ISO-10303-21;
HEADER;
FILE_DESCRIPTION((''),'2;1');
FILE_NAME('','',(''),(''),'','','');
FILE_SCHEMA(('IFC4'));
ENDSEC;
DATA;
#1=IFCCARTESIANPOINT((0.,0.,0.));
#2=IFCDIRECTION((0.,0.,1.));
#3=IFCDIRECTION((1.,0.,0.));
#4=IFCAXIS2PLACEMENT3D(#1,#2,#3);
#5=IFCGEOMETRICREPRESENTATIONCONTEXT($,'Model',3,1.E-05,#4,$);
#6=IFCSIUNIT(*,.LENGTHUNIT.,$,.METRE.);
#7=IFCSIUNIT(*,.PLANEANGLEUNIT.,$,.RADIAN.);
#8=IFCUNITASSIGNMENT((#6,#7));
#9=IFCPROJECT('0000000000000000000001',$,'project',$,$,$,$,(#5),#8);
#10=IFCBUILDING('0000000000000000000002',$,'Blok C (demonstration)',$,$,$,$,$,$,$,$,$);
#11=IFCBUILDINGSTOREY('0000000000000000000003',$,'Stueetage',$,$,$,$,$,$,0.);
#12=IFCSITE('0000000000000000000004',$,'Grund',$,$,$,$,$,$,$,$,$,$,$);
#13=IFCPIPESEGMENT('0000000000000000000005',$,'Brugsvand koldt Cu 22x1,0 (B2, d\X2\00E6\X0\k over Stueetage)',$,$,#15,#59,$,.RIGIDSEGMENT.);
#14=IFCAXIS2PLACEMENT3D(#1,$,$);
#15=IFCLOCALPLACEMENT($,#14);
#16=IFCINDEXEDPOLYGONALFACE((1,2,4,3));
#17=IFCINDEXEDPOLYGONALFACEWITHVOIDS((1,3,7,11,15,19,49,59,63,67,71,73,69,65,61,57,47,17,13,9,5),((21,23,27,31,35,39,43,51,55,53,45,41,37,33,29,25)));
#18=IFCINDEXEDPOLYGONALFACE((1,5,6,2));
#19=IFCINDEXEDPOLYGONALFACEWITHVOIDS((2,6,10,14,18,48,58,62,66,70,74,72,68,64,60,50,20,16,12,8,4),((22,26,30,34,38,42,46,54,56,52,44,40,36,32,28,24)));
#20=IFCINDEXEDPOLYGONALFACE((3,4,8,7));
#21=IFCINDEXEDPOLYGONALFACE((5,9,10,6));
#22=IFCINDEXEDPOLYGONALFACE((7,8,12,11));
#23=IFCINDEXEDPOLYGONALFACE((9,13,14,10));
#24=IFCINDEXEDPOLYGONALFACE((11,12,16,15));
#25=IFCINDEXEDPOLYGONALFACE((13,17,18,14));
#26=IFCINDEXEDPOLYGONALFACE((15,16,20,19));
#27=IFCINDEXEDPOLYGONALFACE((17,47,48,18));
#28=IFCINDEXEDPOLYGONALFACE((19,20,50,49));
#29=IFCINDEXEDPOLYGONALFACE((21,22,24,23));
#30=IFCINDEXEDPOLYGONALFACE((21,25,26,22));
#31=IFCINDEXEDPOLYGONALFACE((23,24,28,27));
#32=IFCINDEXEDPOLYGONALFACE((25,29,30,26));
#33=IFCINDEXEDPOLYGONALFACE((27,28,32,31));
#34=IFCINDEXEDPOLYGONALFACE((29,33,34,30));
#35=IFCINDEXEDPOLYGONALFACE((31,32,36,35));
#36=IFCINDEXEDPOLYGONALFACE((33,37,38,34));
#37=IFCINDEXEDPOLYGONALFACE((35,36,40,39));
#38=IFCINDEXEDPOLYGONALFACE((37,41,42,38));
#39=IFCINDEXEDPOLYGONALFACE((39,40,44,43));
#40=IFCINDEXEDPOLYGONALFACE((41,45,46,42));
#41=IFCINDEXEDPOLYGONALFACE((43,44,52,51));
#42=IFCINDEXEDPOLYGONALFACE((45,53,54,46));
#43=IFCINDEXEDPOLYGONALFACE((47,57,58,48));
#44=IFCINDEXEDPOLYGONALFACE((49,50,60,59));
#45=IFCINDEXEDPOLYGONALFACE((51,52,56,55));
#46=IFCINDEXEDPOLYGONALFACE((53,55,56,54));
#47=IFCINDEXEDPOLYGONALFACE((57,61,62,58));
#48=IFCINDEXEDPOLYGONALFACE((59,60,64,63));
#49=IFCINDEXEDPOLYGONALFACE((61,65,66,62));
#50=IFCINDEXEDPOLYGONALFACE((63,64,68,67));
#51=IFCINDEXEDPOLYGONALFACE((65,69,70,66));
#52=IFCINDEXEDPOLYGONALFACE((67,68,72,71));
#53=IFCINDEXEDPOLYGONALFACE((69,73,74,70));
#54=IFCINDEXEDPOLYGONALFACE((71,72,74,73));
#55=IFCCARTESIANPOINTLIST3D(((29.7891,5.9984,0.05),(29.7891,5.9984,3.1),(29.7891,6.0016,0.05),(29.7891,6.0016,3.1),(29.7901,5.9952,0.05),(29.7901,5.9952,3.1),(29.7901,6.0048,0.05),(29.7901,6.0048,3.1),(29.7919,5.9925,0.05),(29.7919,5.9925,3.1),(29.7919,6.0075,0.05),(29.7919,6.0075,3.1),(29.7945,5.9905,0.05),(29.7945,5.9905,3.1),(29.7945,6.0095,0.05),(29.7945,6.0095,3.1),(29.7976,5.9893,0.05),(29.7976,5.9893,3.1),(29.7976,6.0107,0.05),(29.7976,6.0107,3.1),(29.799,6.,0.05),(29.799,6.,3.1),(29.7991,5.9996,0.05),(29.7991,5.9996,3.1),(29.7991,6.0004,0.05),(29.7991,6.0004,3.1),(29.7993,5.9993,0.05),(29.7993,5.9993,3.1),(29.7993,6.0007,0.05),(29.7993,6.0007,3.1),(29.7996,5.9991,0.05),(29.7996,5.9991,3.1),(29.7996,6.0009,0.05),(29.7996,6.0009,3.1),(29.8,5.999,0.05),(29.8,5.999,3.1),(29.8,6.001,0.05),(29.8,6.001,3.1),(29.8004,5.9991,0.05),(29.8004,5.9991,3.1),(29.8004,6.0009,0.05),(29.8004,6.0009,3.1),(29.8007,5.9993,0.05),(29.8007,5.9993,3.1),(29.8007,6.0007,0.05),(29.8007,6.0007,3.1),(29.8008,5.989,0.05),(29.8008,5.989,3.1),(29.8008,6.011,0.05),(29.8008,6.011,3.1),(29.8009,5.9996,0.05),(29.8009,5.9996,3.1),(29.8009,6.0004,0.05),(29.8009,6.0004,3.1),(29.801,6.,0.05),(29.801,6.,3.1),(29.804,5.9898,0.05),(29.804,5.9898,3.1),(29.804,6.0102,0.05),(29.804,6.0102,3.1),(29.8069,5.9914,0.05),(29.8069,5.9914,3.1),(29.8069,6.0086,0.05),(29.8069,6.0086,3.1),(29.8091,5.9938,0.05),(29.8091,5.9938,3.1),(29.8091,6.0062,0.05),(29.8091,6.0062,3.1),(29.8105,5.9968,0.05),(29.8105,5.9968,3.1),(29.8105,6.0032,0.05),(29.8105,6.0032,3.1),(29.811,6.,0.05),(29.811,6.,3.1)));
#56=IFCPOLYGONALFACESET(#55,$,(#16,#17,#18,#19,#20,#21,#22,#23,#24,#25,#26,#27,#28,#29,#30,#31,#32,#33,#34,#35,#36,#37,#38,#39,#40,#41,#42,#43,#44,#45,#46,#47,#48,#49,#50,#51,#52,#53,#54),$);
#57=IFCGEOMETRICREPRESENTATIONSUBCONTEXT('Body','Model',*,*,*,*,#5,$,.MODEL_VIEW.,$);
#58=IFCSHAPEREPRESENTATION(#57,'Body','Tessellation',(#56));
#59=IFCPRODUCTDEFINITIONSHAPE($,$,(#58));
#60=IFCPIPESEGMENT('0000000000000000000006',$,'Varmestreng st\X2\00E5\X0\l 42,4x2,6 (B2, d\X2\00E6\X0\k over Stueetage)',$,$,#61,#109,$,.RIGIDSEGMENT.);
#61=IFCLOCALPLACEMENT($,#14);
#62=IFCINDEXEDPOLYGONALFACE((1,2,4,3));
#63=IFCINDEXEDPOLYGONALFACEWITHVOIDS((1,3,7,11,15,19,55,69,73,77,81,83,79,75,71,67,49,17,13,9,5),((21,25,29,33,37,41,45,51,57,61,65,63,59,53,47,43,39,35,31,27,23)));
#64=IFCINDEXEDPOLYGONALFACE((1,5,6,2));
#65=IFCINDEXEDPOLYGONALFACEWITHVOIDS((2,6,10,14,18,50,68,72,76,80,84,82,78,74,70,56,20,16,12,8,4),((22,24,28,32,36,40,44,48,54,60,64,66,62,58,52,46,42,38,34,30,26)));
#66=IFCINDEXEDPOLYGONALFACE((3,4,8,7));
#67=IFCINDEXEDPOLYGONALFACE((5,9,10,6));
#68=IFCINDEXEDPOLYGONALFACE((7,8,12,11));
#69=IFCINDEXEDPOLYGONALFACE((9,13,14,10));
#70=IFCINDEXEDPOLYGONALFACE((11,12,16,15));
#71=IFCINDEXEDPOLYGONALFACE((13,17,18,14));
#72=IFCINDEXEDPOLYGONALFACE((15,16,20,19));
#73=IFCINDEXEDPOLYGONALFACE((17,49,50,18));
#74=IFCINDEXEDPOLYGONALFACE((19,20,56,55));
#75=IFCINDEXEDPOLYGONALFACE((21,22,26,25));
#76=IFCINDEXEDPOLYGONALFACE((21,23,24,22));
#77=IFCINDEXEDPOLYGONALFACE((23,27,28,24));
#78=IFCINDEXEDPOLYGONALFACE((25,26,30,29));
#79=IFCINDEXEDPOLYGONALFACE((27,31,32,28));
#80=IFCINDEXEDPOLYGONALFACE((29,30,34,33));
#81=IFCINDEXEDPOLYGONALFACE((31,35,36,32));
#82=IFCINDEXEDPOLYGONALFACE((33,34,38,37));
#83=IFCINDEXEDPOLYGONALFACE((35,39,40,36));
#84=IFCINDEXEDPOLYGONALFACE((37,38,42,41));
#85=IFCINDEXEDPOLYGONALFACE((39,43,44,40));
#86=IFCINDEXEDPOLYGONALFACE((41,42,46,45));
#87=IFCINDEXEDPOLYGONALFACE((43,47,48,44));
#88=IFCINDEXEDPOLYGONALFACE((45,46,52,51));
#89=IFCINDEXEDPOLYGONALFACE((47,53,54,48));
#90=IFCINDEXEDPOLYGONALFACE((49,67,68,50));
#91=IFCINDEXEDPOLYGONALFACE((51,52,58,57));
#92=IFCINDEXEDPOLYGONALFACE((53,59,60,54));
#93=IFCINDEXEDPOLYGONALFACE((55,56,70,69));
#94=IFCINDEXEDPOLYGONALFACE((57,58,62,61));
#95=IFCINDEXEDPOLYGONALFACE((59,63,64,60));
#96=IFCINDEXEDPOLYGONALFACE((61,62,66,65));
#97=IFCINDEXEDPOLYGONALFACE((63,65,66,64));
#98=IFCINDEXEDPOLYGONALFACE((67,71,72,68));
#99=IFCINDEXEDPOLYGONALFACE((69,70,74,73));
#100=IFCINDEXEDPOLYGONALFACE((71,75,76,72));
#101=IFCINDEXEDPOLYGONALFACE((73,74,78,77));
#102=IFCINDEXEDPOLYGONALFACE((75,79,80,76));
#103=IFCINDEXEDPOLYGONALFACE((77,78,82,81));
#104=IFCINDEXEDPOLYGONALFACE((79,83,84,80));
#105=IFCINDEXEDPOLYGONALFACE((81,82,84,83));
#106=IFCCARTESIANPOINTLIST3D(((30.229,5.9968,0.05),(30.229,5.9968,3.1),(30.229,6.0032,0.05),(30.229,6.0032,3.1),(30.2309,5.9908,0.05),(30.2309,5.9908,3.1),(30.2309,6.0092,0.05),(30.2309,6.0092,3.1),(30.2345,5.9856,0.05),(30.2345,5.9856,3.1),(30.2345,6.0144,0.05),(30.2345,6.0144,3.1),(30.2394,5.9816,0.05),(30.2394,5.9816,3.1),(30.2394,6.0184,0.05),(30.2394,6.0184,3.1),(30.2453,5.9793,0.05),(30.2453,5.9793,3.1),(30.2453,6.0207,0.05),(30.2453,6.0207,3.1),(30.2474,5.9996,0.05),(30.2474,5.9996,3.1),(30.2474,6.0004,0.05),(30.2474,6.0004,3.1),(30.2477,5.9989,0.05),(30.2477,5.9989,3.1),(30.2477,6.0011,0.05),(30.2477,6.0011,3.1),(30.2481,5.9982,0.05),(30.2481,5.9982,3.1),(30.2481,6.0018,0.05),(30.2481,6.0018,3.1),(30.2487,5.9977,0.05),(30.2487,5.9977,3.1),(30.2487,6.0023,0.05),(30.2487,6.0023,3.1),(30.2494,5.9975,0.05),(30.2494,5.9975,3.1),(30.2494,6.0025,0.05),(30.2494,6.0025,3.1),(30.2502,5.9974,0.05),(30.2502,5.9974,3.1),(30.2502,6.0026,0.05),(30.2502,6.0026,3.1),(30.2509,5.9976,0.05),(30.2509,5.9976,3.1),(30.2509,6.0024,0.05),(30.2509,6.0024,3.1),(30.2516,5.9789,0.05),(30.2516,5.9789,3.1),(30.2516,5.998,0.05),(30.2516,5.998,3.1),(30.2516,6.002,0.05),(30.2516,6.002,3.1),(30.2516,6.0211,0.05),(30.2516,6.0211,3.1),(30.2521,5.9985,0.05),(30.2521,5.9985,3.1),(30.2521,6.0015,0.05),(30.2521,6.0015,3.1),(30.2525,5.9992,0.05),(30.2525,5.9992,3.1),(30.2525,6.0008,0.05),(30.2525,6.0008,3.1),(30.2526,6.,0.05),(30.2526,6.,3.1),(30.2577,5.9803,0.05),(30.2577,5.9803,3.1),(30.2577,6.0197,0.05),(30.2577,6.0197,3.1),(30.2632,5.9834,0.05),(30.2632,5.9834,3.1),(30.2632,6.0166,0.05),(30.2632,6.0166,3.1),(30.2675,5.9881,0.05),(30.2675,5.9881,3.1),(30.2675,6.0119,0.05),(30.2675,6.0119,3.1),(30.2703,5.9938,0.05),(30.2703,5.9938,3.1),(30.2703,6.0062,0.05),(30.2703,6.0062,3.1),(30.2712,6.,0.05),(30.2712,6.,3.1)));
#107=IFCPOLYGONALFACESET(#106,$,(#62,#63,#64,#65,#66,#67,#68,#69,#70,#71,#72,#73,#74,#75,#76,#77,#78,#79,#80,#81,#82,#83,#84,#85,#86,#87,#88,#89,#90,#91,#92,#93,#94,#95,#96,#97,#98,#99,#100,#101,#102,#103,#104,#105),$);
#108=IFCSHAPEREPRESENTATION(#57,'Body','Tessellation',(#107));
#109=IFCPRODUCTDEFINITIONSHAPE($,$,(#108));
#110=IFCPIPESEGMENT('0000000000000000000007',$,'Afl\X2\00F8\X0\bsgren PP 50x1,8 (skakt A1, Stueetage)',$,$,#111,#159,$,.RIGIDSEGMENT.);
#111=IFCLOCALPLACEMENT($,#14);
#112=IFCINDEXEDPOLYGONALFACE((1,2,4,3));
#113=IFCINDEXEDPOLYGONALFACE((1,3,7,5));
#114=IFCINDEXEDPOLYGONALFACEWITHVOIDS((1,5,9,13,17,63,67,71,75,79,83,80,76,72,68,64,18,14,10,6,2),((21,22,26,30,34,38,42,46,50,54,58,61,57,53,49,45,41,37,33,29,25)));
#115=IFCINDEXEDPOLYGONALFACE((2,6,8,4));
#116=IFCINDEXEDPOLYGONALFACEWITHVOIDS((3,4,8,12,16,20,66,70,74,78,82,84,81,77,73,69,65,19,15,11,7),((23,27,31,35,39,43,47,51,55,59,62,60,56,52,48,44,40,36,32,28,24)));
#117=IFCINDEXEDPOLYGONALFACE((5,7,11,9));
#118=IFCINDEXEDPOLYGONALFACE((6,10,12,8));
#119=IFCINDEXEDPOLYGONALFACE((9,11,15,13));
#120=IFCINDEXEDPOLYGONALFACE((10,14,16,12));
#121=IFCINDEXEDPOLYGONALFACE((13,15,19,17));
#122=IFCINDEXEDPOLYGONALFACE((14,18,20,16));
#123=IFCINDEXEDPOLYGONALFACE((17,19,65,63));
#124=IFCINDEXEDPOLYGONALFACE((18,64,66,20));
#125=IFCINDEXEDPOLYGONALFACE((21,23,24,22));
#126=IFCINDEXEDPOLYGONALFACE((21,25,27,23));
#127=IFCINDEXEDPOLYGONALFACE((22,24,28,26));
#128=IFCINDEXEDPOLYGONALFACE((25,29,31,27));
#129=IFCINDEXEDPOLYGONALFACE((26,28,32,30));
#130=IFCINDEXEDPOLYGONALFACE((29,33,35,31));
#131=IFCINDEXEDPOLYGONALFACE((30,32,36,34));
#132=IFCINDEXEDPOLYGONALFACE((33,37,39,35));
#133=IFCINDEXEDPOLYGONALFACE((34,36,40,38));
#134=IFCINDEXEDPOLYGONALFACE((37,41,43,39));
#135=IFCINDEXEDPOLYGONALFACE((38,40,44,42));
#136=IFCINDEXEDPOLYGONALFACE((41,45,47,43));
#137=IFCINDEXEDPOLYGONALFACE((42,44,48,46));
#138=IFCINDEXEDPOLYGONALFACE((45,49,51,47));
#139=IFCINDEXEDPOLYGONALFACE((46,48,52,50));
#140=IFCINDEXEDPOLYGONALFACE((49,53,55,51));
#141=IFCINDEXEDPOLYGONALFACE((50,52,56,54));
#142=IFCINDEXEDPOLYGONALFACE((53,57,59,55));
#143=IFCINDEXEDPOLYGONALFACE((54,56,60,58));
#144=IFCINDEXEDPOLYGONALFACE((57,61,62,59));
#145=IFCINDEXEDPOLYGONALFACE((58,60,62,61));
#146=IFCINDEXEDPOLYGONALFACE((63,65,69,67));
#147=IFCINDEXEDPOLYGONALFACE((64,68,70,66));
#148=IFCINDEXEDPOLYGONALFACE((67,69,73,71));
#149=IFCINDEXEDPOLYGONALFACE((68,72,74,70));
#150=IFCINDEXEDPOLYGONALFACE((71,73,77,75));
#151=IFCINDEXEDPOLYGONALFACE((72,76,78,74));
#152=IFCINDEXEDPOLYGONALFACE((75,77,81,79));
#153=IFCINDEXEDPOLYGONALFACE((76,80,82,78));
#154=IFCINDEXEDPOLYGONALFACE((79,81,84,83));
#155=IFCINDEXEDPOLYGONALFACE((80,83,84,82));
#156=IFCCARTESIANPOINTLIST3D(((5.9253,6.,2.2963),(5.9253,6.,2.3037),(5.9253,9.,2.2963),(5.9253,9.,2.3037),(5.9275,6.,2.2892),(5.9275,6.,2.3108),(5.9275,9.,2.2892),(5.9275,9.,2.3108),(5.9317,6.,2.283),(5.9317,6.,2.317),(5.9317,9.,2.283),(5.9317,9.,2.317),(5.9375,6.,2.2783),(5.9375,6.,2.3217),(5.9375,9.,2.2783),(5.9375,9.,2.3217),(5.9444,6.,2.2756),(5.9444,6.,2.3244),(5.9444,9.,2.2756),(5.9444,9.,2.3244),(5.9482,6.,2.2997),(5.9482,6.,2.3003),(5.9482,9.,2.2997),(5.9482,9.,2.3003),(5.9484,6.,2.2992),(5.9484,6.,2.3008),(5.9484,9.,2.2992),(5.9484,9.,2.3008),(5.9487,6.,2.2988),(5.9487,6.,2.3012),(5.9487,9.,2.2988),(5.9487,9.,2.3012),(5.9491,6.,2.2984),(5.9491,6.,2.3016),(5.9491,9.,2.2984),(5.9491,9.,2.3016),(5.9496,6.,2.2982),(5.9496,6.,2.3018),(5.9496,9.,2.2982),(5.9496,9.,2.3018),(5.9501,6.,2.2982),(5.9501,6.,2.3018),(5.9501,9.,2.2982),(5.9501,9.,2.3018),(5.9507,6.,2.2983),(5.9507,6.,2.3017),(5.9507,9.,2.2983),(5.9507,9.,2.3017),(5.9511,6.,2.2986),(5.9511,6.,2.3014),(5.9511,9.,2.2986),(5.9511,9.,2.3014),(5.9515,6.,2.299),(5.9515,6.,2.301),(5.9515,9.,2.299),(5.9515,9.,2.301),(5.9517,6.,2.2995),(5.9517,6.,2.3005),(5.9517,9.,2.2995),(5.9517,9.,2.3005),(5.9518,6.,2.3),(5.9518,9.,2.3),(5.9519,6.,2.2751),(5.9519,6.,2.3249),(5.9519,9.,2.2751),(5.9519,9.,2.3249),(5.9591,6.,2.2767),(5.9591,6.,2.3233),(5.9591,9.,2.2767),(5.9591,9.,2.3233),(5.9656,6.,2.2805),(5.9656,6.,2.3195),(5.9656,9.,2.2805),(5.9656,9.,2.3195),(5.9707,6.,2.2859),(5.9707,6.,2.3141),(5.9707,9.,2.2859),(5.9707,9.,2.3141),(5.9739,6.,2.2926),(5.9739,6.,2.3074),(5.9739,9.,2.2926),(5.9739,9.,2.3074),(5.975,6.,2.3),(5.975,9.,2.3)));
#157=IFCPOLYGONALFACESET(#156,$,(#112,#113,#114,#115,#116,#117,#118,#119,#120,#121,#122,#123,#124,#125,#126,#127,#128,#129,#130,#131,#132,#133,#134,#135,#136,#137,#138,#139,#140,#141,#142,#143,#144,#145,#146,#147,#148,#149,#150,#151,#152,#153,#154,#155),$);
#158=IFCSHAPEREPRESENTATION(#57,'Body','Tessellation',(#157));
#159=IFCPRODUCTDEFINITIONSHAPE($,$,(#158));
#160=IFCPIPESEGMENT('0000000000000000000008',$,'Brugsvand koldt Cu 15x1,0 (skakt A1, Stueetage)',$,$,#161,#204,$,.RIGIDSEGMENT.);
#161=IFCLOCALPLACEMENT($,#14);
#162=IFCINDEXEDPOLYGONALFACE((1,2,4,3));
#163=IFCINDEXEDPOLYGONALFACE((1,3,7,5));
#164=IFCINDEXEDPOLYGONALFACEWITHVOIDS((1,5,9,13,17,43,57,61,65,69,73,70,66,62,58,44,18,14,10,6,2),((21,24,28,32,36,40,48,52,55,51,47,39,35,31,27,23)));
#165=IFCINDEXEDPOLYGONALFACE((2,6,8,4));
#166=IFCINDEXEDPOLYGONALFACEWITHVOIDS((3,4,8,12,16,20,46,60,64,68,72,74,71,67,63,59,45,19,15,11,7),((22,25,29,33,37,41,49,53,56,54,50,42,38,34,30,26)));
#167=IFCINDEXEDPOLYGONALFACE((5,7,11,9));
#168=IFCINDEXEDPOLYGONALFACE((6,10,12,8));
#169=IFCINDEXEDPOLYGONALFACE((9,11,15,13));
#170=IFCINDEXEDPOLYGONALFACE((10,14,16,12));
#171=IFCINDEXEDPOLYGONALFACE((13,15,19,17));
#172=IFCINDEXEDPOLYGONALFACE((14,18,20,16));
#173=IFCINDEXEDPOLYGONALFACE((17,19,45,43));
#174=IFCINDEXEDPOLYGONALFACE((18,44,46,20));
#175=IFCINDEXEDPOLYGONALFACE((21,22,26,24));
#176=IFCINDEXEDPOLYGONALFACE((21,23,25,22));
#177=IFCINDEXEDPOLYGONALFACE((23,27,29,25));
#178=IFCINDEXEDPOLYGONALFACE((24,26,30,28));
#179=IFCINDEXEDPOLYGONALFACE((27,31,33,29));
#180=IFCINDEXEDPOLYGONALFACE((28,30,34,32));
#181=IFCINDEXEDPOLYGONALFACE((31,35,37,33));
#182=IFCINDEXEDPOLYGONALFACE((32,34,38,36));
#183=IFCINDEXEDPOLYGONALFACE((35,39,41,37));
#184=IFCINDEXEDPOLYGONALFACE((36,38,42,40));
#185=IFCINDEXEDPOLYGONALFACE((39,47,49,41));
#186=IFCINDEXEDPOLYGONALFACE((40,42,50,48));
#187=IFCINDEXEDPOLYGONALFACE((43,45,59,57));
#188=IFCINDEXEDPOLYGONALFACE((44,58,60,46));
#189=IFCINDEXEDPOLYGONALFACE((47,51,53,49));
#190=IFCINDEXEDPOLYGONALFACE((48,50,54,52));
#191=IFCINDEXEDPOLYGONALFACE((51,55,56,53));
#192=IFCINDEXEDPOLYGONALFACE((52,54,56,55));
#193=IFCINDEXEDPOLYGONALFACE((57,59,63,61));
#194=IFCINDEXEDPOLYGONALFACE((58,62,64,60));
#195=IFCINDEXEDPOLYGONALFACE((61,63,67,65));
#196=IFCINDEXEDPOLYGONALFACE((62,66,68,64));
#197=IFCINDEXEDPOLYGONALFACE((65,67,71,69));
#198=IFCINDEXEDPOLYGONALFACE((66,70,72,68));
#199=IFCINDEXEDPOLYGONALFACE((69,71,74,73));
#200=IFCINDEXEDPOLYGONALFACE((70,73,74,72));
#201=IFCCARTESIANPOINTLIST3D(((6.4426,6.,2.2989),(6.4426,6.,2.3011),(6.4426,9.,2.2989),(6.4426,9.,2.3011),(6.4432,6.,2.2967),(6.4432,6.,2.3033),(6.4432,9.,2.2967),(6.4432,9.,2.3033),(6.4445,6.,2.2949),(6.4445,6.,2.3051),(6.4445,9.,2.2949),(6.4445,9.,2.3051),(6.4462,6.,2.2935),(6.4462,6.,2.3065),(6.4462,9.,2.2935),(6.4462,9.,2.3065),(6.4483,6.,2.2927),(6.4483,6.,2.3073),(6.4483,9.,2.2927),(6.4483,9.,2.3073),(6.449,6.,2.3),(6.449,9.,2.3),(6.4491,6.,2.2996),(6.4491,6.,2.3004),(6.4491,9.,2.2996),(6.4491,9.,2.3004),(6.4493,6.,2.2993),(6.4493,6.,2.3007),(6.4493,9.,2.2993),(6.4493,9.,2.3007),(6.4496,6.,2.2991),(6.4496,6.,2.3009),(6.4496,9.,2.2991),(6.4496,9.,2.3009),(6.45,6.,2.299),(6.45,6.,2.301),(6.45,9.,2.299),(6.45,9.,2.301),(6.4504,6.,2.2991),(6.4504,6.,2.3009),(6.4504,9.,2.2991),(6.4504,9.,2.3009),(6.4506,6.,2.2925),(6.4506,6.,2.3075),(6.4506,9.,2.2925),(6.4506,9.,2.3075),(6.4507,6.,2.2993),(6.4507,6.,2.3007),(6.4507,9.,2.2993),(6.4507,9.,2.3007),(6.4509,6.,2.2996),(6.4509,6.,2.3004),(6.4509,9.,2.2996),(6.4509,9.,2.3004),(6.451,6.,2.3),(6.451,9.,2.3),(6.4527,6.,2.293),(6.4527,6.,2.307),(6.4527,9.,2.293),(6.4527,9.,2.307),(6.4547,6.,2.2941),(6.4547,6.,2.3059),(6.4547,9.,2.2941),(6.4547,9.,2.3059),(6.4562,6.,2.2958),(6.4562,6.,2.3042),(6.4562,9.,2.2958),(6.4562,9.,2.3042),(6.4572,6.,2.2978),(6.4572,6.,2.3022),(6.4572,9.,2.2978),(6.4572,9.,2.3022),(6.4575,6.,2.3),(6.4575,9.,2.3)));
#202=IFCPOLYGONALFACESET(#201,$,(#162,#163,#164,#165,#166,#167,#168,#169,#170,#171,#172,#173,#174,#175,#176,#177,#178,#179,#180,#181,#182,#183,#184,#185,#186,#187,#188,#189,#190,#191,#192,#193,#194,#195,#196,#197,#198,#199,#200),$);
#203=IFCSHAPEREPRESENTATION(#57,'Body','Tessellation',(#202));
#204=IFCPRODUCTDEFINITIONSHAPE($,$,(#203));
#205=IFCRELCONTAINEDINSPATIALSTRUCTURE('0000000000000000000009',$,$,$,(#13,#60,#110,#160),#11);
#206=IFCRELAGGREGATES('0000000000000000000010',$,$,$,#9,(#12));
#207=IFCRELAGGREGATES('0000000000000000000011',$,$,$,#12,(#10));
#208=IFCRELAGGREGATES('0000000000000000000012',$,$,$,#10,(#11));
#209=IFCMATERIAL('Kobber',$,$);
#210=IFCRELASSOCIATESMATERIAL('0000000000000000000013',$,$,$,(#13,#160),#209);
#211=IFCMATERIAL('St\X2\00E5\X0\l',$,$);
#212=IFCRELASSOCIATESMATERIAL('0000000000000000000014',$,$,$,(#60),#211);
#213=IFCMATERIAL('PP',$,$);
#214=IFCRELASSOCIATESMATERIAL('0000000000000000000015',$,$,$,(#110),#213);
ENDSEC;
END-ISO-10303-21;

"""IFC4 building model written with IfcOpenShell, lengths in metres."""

from ifc_helpers import new_model, si_unit, frame, origin_with_axes, place, context, subcontext, project, spatial, hollow_circle, extrude, material, element, save


model = new_model("IFC4")

# Units and contexts
model_context = context("Model", 3, precision=1e-05, world=origin_with_axes())
body_context = subcontext(model_context, "Body", "Model", "MODEL_VIEW")
ifc_project = project(units=[si_unit("LENGTHUNIT", "METRE"), si_unit("PLANEANGLEUNIT", "RADIAN")], contexts=[model_context])

# Site, building, storey
site = spatial("IfcSite", under=ifc_project, Name="Grund")
building = spatial("IfcBuilding", under=site, Name="Blok C (demonstration)")
storey = spatial("IfcBuildingStorey", under=building, Name="Stueetage", Elevation=0.0)

# Pipe segments
ifc_material_1 = material(Name="Kobber")
ifc_material_2 = material(Name="PP")
pipe_segment_1_placement = place(None, origin_with_axes())
element("IfcPipeSegment", 1, at=pipe_segment_1_placement, inside=storey, material=ifc_material_1, Name="Brugsvand koldt Cu 22x1,0 (B2, dæk over Stueetage)", PredefinedType="RIGIDSEGMENT", context=body_context, shape_type="SweptSolid", body=[
    extrude(hollow_circle(Radius=0.011, WallThickness=0.01), frame((29.8, 6.0, 0.05), z_axis=(0.0, 0.0, 1.0), x_axis=(1.0, 0.0, 0.0)), (0.0, 0.0, 1.0), 3.05),
])
ifc_material_3 = material(Name="Stål")
pipe_segment_2_placement = place(None, origin_with_axes())
element("IfcPipeSegment", 2, at=pipe_segment_2_placement, inside=storey, material=ifc_material_3, Name="Varmestreng stål 42,4x2,6 (B2, dæk over Stueetage)", PredefinedType="RIGIDSEGMENT", context=body_context, shape_type="SweptSolid", body=[
    extrude(hollow_circle(Radius=0.0212, WallThickness=0.0186), frame((30.25, 6.0, 0.05), z_axis=(0.0, 0.0, 1.0), x_axis=(1.0, 0.0, 0.0)), (0.0, 0.0, 1.0), 3.05),
])
pipe_segment_3_placement = place(None, origin_with_axes())
element("IfcPipeSegment", 3, at=pipe_segment_3_placement, inside=storey, material=ifc_material_2, Name="Afløbsgren PP 50x1,8 (skakt A1, Stueetage)", PredefinedType="RIGIDSEGMENT", context=body_context, shape_type="SweptSolid", body=[
    extrude(hollow_circle(Radius=0.025, WallThickness=0.0232), frame((5.95, 6.0, 2.3), z_axis=(0.0, 1.0, 0.0), x_axis=(1.0, 0.0, 0.0)), (0.0, 0.0, 1.0), 3.0),
])
pipe_segment_4_placement = place(None, origin_with_axes())
element("IfcPipeSegment", 4, at=pipe_segment_4_placement, inside=storey, material=ifc_material_1, Name="Brugsvand koldt Cu 15x1,0 (skakt A1, Stueetage)", PredefinedType="RIGIDSEGMENT", context=body_context, shape_type="SweptSolid", body=[
    extrude(hollow_circle(Radius=0.0075, WallThickness=0.0065), frame((6.45, 6.0, 2.3), z_axis=(0.0, 1.0, 0.0), x_axis=(1.0, 0.0, 0.0)), (0.0, 0.0, 1.0), 3.0),
])

save(model, "model.ifc")
